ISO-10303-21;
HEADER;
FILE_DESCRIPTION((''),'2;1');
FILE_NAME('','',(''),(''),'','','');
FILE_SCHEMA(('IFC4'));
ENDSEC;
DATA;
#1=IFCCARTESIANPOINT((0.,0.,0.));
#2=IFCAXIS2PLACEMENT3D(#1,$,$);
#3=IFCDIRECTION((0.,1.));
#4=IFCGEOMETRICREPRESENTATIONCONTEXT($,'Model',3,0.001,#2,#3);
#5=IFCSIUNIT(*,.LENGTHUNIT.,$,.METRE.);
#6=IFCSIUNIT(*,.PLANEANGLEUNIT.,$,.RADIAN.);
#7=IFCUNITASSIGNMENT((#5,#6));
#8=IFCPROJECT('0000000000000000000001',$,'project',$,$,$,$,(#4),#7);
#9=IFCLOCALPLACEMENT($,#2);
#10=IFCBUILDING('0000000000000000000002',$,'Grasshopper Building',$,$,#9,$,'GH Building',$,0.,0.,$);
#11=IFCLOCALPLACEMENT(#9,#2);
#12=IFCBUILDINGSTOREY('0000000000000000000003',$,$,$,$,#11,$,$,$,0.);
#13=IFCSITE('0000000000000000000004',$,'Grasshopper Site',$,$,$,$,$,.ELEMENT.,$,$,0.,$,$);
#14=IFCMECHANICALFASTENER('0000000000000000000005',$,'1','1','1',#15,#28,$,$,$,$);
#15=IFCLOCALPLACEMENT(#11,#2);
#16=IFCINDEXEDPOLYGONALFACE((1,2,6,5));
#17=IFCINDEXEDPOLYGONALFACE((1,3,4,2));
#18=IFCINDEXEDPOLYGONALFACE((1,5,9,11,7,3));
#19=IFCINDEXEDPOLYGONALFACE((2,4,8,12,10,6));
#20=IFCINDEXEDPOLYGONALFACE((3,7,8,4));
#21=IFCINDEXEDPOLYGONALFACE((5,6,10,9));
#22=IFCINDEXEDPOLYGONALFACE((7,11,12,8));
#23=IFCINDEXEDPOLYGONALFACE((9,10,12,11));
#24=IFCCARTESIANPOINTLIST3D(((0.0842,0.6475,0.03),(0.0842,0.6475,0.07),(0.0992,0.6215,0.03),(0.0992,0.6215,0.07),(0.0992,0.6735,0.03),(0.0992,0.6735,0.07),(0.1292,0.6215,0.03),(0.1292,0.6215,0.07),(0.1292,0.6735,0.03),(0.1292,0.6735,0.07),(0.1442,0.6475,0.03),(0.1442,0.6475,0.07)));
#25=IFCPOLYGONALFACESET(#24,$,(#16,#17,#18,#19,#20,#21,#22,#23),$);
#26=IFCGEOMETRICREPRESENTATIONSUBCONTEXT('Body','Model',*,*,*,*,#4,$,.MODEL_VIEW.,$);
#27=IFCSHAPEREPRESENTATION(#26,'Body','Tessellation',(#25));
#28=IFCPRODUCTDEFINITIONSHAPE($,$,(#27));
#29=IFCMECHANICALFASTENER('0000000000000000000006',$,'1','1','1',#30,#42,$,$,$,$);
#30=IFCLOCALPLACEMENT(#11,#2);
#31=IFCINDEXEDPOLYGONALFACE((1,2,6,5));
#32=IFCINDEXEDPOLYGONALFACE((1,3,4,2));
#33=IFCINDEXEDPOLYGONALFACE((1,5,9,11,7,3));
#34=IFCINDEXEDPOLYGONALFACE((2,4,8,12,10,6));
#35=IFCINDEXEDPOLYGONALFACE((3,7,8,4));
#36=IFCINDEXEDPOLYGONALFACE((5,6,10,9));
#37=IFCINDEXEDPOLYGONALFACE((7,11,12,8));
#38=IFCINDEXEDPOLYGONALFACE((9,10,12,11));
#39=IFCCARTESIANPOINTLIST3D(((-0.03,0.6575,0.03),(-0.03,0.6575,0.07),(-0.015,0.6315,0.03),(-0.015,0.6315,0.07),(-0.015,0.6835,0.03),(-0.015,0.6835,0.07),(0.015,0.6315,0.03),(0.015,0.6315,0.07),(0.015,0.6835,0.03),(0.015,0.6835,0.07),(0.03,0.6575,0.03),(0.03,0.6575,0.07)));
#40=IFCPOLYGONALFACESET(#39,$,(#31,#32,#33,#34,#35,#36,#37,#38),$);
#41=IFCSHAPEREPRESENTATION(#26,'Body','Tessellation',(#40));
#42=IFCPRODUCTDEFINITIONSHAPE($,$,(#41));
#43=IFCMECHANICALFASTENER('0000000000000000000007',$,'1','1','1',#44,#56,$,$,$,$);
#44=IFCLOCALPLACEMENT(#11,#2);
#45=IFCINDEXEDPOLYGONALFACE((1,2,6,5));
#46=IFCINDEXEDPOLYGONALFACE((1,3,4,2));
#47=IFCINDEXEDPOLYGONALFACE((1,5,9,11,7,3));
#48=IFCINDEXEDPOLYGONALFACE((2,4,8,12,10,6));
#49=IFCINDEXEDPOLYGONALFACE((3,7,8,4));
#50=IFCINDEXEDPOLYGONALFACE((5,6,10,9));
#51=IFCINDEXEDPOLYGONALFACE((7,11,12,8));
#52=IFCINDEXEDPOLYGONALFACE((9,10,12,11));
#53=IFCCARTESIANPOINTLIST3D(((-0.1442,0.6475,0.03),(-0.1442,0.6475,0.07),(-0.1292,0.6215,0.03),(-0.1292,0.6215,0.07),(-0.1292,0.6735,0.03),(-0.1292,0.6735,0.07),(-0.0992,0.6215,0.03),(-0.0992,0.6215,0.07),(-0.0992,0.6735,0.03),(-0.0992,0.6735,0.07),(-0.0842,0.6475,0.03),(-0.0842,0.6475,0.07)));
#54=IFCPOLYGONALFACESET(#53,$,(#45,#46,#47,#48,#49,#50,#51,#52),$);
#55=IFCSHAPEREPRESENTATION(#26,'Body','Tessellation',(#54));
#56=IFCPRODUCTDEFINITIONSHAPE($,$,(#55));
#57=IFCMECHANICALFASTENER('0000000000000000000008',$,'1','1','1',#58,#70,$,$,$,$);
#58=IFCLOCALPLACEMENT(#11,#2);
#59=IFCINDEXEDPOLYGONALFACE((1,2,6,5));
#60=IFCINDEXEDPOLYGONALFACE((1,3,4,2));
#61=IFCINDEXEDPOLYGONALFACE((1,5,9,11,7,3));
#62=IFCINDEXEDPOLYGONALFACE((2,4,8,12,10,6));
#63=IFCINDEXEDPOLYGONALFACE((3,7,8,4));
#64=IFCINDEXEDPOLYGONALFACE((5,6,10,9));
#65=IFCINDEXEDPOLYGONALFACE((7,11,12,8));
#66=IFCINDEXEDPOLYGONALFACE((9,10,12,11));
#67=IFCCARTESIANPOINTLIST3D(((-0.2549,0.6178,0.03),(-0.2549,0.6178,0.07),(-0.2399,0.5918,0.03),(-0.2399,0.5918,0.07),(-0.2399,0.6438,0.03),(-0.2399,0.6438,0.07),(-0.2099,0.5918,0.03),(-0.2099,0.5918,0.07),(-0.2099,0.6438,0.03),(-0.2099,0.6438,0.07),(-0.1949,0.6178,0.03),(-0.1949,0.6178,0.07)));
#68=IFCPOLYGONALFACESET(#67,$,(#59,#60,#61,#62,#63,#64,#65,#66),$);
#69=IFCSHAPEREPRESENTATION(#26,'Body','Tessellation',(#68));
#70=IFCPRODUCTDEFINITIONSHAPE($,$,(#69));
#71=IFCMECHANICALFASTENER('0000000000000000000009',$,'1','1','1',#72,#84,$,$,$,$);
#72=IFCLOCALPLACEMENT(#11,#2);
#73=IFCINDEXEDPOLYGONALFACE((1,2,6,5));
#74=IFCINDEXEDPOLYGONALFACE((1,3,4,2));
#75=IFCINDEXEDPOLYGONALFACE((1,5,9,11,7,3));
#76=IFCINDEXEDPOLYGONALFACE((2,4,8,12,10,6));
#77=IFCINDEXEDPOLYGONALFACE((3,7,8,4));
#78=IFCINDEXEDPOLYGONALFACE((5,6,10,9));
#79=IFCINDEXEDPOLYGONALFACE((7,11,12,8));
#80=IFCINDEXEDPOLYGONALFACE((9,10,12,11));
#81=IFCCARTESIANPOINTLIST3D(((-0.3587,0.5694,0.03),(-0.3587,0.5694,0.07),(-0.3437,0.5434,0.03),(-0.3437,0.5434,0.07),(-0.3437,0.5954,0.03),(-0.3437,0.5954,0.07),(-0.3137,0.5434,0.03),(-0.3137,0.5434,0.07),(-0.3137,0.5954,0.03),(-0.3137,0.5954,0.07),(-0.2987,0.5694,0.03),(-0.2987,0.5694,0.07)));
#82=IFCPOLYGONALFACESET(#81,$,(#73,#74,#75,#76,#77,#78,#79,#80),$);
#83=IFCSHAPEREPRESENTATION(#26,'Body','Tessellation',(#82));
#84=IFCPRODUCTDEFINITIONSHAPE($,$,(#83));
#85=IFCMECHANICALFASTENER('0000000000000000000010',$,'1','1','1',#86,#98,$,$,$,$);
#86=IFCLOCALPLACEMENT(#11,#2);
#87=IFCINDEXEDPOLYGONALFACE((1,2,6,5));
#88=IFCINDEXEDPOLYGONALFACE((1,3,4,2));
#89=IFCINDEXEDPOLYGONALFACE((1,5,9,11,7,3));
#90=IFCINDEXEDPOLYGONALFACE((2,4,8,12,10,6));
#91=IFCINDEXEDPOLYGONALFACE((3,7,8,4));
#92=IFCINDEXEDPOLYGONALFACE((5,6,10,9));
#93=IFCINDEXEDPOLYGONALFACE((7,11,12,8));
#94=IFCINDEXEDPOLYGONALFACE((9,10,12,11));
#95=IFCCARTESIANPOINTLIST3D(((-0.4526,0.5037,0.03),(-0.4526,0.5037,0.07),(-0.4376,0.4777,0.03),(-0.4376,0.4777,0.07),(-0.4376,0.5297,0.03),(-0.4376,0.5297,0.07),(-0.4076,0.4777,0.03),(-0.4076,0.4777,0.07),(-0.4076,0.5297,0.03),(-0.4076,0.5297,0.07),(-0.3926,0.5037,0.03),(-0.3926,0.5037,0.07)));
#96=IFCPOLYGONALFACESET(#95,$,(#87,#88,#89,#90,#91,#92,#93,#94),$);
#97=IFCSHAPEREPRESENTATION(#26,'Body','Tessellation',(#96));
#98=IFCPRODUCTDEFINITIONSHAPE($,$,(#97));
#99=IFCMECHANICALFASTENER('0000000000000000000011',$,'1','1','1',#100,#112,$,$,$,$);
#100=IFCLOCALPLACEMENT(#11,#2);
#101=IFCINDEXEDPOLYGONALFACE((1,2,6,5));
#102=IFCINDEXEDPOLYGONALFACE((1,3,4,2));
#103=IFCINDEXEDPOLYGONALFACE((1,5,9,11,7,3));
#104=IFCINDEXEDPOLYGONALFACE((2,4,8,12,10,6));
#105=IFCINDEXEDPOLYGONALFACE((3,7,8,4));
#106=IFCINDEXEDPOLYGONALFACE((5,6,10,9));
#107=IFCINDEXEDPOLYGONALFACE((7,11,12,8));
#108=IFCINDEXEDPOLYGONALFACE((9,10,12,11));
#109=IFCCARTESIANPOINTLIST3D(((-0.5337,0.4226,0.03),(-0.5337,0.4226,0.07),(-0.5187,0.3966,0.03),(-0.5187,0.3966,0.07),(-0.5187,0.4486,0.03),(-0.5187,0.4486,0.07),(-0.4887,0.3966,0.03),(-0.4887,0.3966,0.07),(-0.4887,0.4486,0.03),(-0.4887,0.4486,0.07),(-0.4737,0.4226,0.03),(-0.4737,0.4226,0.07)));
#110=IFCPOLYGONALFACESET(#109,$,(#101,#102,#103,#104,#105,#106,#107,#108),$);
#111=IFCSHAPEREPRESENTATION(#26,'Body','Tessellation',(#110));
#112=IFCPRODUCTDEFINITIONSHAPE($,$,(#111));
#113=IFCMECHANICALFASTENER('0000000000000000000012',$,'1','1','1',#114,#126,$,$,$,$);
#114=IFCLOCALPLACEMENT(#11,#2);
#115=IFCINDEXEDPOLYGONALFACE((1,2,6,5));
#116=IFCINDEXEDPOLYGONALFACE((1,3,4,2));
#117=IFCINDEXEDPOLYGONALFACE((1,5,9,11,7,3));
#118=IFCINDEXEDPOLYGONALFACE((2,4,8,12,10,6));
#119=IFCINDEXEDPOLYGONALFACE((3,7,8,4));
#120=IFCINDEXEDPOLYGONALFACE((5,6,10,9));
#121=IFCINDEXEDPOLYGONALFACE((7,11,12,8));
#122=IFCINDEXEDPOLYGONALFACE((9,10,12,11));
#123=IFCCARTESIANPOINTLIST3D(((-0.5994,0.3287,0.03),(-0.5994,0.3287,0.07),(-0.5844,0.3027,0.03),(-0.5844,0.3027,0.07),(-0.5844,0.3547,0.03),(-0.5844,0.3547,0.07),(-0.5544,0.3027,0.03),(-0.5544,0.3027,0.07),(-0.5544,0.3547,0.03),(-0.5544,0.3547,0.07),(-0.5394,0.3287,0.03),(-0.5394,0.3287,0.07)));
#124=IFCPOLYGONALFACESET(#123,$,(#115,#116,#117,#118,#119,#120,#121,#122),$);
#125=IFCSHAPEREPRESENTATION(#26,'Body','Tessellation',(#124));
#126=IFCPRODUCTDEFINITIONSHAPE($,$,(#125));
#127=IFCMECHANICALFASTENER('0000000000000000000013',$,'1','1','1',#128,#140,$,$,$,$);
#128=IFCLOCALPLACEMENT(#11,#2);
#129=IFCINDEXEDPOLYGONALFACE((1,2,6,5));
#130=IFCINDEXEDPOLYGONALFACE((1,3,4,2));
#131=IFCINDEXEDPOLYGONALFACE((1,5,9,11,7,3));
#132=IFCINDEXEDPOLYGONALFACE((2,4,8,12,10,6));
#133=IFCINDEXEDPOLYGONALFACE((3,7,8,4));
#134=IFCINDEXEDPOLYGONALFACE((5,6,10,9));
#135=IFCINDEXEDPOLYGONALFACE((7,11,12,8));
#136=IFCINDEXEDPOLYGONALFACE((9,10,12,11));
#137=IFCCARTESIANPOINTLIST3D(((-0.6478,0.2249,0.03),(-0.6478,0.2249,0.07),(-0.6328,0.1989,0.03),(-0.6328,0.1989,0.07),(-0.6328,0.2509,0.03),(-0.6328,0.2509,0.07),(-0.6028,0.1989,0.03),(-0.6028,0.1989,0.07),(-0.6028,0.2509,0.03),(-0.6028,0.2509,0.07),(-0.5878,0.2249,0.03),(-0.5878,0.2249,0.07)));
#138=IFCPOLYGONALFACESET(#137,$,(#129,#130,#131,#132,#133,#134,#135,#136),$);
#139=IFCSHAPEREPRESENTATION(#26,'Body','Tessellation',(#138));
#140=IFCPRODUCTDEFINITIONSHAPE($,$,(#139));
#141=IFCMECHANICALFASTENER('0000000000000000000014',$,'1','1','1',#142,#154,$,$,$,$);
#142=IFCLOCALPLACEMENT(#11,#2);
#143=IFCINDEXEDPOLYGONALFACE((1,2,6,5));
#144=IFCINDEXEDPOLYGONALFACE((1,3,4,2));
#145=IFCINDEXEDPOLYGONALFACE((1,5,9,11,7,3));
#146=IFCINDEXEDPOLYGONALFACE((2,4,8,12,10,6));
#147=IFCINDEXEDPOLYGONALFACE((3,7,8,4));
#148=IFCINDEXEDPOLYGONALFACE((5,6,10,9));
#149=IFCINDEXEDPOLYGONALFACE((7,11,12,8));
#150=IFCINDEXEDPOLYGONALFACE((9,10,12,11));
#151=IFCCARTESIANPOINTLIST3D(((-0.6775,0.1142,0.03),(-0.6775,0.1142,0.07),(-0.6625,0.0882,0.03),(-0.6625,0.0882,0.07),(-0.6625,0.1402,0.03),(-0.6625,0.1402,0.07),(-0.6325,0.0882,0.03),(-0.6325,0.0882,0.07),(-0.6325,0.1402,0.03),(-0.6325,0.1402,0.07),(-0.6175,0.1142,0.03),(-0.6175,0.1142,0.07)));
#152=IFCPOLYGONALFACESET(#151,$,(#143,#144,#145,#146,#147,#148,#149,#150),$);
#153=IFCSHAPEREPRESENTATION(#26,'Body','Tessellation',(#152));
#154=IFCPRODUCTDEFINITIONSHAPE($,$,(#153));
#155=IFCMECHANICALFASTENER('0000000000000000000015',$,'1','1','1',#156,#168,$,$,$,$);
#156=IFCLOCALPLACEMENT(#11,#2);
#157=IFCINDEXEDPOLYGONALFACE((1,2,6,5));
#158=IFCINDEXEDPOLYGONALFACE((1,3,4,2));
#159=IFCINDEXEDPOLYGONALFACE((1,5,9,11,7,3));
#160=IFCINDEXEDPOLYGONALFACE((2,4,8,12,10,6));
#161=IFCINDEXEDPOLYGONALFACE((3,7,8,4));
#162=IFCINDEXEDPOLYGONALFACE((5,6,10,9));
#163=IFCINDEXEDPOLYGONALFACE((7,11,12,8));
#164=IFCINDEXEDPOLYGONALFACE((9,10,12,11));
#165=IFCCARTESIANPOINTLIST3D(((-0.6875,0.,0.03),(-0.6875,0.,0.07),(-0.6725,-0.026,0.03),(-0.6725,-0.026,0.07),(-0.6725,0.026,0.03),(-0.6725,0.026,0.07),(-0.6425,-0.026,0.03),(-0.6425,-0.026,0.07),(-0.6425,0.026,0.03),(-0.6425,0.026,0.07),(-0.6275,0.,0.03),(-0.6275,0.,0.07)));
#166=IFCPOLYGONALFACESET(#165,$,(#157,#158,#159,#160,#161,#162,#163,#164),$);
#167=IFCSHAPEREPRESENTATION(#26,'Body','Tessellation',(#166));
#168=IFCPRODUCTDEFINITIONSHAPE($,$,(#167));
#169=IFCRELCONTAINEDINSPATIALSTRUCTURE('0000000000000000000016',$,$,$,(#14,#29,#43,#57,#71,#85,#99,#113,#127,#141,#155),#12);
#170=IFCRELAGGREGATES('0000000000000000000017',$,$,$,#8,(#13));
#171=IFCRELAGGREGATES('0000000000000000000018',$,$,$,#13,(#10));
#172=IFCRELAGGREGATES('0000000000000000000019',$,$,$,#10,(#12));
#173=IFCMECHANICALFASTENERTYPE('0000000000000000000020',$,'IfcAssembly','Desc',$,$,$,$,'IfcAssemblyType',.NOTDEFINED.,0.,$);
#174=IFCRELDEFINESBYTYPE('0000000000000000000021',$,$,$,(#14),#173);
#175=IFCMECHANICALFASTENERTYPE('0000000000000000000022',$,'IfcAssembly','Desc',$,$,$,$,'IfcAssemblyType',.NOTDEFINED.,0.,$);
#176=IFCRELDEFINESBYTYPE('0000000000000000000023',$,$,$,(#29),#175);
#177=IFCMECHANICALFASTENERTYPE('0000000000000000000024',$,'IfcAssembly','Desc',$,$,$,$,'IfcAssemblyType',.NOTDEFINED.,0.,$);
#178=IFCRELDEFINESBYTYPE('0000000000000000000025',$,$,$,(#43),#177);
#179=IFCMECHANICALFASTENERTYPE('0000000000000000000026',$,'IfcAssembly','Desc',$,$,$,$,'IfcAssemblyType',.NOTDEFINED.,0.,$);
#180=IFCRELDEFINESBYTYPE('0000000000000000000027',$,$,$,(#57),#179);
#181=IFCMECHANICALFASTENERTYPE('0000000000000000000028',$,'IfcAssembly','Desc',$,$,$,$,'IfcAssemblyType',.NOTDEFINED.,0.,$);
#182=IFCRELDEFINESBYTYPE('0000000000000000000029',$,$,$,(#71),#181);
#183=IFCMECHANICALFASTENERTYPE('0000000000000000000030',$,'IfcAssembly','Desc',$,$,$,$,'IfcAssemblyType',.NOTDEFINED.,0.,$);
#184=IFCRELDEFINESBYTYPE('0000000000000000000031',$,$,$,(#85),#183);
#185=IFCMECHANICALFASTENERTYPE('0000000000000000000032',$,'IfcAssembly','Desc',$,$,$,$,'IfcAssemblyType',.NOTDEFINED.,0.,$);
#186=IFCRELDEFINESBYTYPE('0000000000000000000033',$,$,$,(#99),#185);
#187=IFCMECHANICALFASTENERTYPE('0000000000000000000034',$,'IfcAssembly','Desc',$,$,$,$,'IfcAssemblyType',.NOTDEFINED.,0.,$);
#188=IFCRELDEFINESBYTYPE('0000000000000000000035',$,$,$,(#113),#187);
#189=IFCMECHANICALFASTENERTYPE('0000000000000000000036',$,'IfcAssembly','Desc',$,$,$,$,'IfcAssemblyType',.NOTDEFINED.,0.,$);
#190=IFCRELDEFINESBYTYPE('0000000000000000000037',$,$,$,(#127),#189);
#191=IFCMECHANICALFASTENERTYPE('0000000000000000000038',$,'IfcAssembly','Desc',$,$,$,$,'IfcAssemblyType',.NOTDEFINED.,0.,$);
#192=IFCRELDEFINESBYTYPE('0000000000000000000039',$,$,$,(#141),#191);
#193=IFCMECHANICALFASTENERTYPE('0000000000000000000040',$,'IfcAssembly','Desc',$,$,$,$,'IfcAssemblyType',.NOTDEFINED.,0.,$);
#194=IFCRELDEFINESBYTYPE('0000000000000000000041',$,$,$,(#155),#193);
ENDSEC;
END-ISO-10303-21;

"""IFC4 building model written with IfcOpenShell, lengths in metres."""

from ifc_helpers import new_model, si_unit, direction, frame, origin, place, context, subcontext, project, spatial, indexed_curve, outline, extrude, source, transform, mapped, type_object, type_shapes, element, save


model = new_model("IFC4")

# Units and contexts
model_context = context("Model", 3, precision=0.001, world=origin(), true_north=direction((0.0, 1.0)))
body_context = subcontext(model_context, "Body", "Model", "MODEL_VIEW")
ifc_project = project(units=[si_unit("LENGTHUNIT", "METRE"), si_unit("PLANEANGLEUNIT", "RADIAN")], contexts=[model_context])

# Site, building, storey
site = spatial("IfcSite", under=ifc_project, Name="Grasshopper Site", CompositionType="ELEMENT", RefElevation=0.0)
building_placement = place(None, origin())
building = spatial("IfcBuilding", under=site, at=building_placement, Name="Grasshopper Building", LongName="GH Building", ElevationOfRefHeight=0.0, ElevationOfTerrain=0.0)
storey_placement = place(building_placement, origin())
storey = spatial("IfcBuildingStorey", under=building, at=storey_placement, Elevation=0.0)

# Mechanical fasteners
mechanical_fastener_type_1 = type_object("IfcMechanicalFastenerType", Name="IfcAssembly", Description="Desc", ElementType="IfcAssemblyType", NominalDiameter=0.0)
shared_shape_1 = source(origin(), body_context, "Body", "SweptSolid", [
    extrude(outline(indexed_curve([(0.03, 0.0), (0.015, 0.026), (-0.015, 0.026), (-0.03, 0.0), (-0.015, -0.026), (0.015, -0.026), (0.03, 0.0)])), frame((0.1142, 0.6475, 0.03)), (0.0, 0.0, 1.0), 0.04),
])
type_shapes(mechanical_fastener_type_1, [shared_shape_1])
mechanical_fastener_1_placement = place(storey_placement, origin())
element("IfcMechanicalFastener", 1, at=mechanical_fastener_1_placement, inside=storey, type_object=mechanical_fastener_type_1, Name="1", Description="1", ObjectType="1", context=body_context, shape_type="MappedRepresentation", body=[
    mapped(shared_shape_1, transform((0.0, 0.0, 0.0), scale=1.0)),
])
mechanical_fastener_type_2 = type_object("IfcMechanicalFastenerType", Name="IfcAssembly", Description="Desc", ElementType="IfcAssemblyType", NominalDiameter=0.0)
shared_shape_2 = source(origin(), body_context, "Body", "SweptSolid", [
    extrude(outline(indexed_curve([(0.03, 0.0), (0.015, 0.026), (-0.015, 0.026), (-0.03, 0.0), (-0.015, -0.026), (0.015, -0.026), (0.03, 0.0)])), frame((0.0, 0.6575, 0.03)), (0.0, 0.0, 1.0), 0.04),
])
type_shapes(mechanical_fastener_type_2, [shared_shape_2])
mechanical_fastener_2_placement = place(storey_placement, origin())
element("IfcMechanicalFastener", 2, at=mechanical_fastener_2_placement, inside=storey, type_object=mechanical_fastener_type_2, Name="1", Description="1", ObjectType="1", context=body_context, shape_type="MappedRepresentation", body=[
    mapped(shared_shape_2, transform((0.0, 0.0, 0.0), scale=1.0)),
])
mechanical_fastener_type_3 = type_object("IfcMechanicalFastenerType", Name="IfcAssembly", Description="Desc", ElementType="IfcAssemblyType", NominalDiameter=0.0)
shared_shape_3 = source(origin(), body_context, "Body", "SweptSolid", [
    extrude(outline(indexed_curve([(0.03, 0.0), (0.015, 0.026), (-0.015, 0.026), (-0.03, 0.0), (-0.015, -0.026), (0.015, -0.026), (0.03, 0.0)])), frame((-0.1142, 0.6475, 0.03)), (0.0, 0.0, 1.0), 0.04),
])
type_shapes(mechanical_fastener_type_3, [shared_shape_3])
mechanical_fastener_3_placement = place(storey_placement, origin())
element("IfcMechanicalFastener", 3, at=mechanical_fastener_3_placement, inside=storey, type_object=mechanical_fastener_type_3, Name="1", Description="1", ObjectType="1", context=body_context, shape_type="MappedRepresentation", body=[
    mapped(shared_shape_3, transform((0.0, 0.0, 0.0), scale=1.0)),
])
mechanical_fastener_type_4 = type_object("IfcMechanicalFastenerType", Name="IfcAssembly", Description="Desc", ElementType="IfcAssemblyType", NominalDiameter=0.0)
shared_shape_4 = source(origin(), body_context, "Body", "SweptSolid", [
    extrude(outline(indexed_curve([(0.03, 0.0), (0.015, 0.026), (-0.015, 0.026), (-0.03, 0.0), (-0.015, -0.026), (0.015, -0.026), (0.03, 0.0)])), frame((-0.2249, 0.6178, 0.03)), (0.0, 0.0, 1.0), 0.04),
])
type_shapes(mechanical_fastener_type_4, [shared_shape_4])
mechanical_fastener_4_placement = place(storey_placement, origin())
element("IfcMechanicalFastener", 4, at=mechanical_fastener_4_placement, inside=storey, type_object=mechanical_fastener_type_4, Name="1", Description="1", ObjectType="1", context=body_context, shape_type="MappedRepresentation", body=[
    mapped(shared_shape_4, transform((0.0, 0.0, 0.0), scale=1.0)),
])
mechanical_fastener_type_5 = type_object("IfcMechanicalFastenerType", Name="IfcAssembly", Description="Desc", ElementType="IfcAssemblyType", NominalDiameter=0.0)
shared_shape_5 = source(origin(), body_context, "Body", "SweptSolid", [
    extrude(outline(indexed_curve([(0.03, 0.0), (0.015, 0.026), (-0.015, 0.026), (-0.03, 0.0), (-0.015, -0.026), (0.015, -0.026), (0.03, 0.0)])), frame((-0.3287, 0.5694, 0.03)), (0.0, 0.0, 1.0), 0.04),
])
type_shapes(mechanical_fastener_type_5, [shared_shape_5])
mechanical_fastener_5_placement = place(storey_placement, origin())
element("IfcMechanicalFastener", 5, at=mechanical_fastener_5_placement, inside=storey, type_object=mechanical_fastener_type_5, Name="1", Description="1", ObjectType="1", context=body_context, shape_type="MappedRepresentation", body=[
    mapped(shared_shape_5, transform((0.0, 0.0, 0.0), scale=1.0)),
])
mechanical_fastener_type_6 = type_object("IfcMechanicalFastenerType", Name="IfcAssembly", Description="Desc", ElementType="IfcAssemblyType", NominalDiameter=0.0)
shared_shape_6 = source(origin(), body_context, "Body", "SweptSolid", [
    extrude(outline(indexed_curve([(0.03, 0.0), (0.015, 0.026), (-0.015, 0.026), (-0.03, 0.0), (-0.015, -0.026), (0.015, -0.026), (0.03, 0.0)])), frame((-0.4226, 0.5037, 0.03)), (0.0, 0.0, 1.0), 0.04),
])
type_shapes(mechanical_fastener_type_6, [shared_shape_6])
mechanical_fastener_6_placement = place(storey_placement, origin())
element("IfcMechanicalFastener", 6, at=mechanical_fastener_6_placement, inside=storey, type_object=mechanical_fastener_type_6, Name="1", Description="1", ObjectType="1", context=body_context, shape_type="MappedRepresentation", body=[
    mapped(shared_shape_6, transform((0.0, 0.0, 0.0), scale=1.0)),
])
mechanical_fastener_type_7 = type_object("IfcMechanicalFastenerType", Name="IfcAssembly", Description="Desc", ElementType="IfcAssemblyType", NominalDiameter=0.0)
shared_shape_7 = source(origin(), body_context, "Body", "SweptSolid", [
    extrude(outline(indexed_curve([(0.03, 0.0), (0.015, 0.026), (-0.015, 0.026), (-0.03, 0.0), (-0.015, -0.026), (0.015, -0.026), (0.03, 0.0)])), frame((-0.5037, 0.4226, 0.03)), (0.0, 0.0, 1.0), 0.04),
])
type_shapes(mechanical_fastener_type_7, [shared_shape_7])
mechanical_fastener_7_placement = place(storey_placement, origin())
element("IfcMechanicalFastener", 7, at=mechanical_fastener_7_placement, inside=storey, type_object=mechanical_fastener_type_7, Name="1", Description="1", ObjectType="1", context=body_context, shape_type="MappedRepresentation", body=[
    mapped(shared_shape_7, transform((0.0, 0.0, 0.0), scale=1.0)),
])
mechanical_fastener_type_8 = type_object("IfcMechanicalFastenerType", Name="IfcAssembly", Description="Desc", ElementType="IfcAssemblyType", NominalDiameter=0.0)
shared_shape_8 = source(origin(), body_context, "Body", "SweptSolid", [
    extrude(outline(indexed_curve([(0.03, 0.0), (0.015, 0.026), (-0.015, 0.026), (-0.03, 0.0), (-0.015, -0.026), (0.015, -0.026), (0.03, 0.0)])), frame((-0.5694, 0.3287, 0.03)), (0.0, 0.0, 1.0), 0.04),
])
type_shapes(mechanical_fastener_type_8, [shared_shape_8])
mechanical_fastener_8_placement = place(storey_placement, origin())
element("IfcMechanicalFastener", 8, at=mechanical_fastener_8_placement, inside=storey, type_object=mechanical_fastener_type_8, Name="1", Description="1", ObjectType="1", context=body_context, shape_type="MappedRepresentation", body=[
    mapped(shared_shape_8, transform((0.0, 0.0, 0.0), scale=1.0)),
])
mechanical_fastener_type_9 = type_object("IfcMechanicalFastenerType", Name="IfcAssembly", Description="Desc", ElementType="IfcAssemblyType", NominalDiameter=0.0)
shared_shape_9 = source(origin(), body_context, "Body", "SweptSolid", [
    extrude(outline(indexed_curve([(0.03, 0.0), (0.015, 0.026), (-0.015, 0.026), (-0.03, 0.0), (-0.015, -0.026), (0.015, -0.026), (0.03, 0.0)])), frame((-0.6178, 0.2249, 0.03)), (0.0, 0.0, 1.0), 0.04),
])
type_shapes(mechanical_fastener_type_9, [shared_shape_9])
mechanical_fastener_9_placement = place(storey_placement, origin())
element("IfcMechanicalFastener", 9, at=mechanical_fastener_9_placement, inside=storey, type_object=mechanical_fastener_type_9, Name="1", Description="1", ObjectType="1", context=body_context, shape_type="MappedRepresentation", body=[
    mapped(shared_shape_9, transform((0.0, 0.0, 0.0), scale=1.0)),
])
mechanical_fastener_type_10 = type_object("IfcMechanicalFastenerType", Name="IfcAssembly", Description="Desc", ElementType="IfcAssemblyType", NominalDiameter=0.0)
shared_shape_10 = source(origin(), body_context, "Body", "SweptSolid", [
    extrude(outline(indexed_curve([(0.03, 0.0), (0.015, 0.026), (-0.015, 0.026), (-0.03, 0.0), (-0.015, -0.026), (0.015, -0.026), (0.03, 0.0)])), frame((-0.6475, 0.1142, 0.03)), (0.0, 0.0, 1.0), 0.04),
])
type_shapes(mechanical_fastener_type_10, [shared_shape_10])
mechanical_fastener_10_placement = place(storey_placement, origin())
element("IfcMechanicalFastener", 10, at=mechanical_fastener_10_placement, inside=storey, type_object=mechanical_fastener_type_10, Name="1", Description="1", ObjectType="1", context=body_context, shape_type="MappedRepresentation", body=[
    mapped(shared_shape_10, transform((0.0, 0.0, 0.0), scale=1.0)),
])
mechanical_fastener_type_11 = type_object("IfcMechanicalFastenerType", Name="IfcAssembly", Description="Desc", ElementType="IfcAssemblyType", NominalDiameter=0.0)
shared_shape_11 = source(origin(), body_context, "Body", "SweptSolid", [
    extrude(outline(indexed_curve([(0.03, 0.0), (0.015, 0.026), (-0.015, 0.026), (-0.03, 0.0), (-0.015, -0.026), (0.015, -0.026), (0.03, 0.0)])), frame((-0.6575, 0.0, 0.03)), (0.0, 0.0, 1.0), 0.04),
])
type_shapes(mechanical_fastener_type_11, [shared_shape_11])
mechanical_fastener_11_placement = place(storey_placement, origin())
element("IfcMechanicalFastener", 11, at=mechanical_fastener_11_placement, inside=storey, type_object=mechanical_fastener_type_11, Name="1", Description="1", ObjectType="1", context=body_context, shape_type="MappedRepresentation", body=[
    mapped(shared_shape_11, transform((0.0, 0.0, 0.0), scale=1.0)),
])

save(model, "model.ifc")
